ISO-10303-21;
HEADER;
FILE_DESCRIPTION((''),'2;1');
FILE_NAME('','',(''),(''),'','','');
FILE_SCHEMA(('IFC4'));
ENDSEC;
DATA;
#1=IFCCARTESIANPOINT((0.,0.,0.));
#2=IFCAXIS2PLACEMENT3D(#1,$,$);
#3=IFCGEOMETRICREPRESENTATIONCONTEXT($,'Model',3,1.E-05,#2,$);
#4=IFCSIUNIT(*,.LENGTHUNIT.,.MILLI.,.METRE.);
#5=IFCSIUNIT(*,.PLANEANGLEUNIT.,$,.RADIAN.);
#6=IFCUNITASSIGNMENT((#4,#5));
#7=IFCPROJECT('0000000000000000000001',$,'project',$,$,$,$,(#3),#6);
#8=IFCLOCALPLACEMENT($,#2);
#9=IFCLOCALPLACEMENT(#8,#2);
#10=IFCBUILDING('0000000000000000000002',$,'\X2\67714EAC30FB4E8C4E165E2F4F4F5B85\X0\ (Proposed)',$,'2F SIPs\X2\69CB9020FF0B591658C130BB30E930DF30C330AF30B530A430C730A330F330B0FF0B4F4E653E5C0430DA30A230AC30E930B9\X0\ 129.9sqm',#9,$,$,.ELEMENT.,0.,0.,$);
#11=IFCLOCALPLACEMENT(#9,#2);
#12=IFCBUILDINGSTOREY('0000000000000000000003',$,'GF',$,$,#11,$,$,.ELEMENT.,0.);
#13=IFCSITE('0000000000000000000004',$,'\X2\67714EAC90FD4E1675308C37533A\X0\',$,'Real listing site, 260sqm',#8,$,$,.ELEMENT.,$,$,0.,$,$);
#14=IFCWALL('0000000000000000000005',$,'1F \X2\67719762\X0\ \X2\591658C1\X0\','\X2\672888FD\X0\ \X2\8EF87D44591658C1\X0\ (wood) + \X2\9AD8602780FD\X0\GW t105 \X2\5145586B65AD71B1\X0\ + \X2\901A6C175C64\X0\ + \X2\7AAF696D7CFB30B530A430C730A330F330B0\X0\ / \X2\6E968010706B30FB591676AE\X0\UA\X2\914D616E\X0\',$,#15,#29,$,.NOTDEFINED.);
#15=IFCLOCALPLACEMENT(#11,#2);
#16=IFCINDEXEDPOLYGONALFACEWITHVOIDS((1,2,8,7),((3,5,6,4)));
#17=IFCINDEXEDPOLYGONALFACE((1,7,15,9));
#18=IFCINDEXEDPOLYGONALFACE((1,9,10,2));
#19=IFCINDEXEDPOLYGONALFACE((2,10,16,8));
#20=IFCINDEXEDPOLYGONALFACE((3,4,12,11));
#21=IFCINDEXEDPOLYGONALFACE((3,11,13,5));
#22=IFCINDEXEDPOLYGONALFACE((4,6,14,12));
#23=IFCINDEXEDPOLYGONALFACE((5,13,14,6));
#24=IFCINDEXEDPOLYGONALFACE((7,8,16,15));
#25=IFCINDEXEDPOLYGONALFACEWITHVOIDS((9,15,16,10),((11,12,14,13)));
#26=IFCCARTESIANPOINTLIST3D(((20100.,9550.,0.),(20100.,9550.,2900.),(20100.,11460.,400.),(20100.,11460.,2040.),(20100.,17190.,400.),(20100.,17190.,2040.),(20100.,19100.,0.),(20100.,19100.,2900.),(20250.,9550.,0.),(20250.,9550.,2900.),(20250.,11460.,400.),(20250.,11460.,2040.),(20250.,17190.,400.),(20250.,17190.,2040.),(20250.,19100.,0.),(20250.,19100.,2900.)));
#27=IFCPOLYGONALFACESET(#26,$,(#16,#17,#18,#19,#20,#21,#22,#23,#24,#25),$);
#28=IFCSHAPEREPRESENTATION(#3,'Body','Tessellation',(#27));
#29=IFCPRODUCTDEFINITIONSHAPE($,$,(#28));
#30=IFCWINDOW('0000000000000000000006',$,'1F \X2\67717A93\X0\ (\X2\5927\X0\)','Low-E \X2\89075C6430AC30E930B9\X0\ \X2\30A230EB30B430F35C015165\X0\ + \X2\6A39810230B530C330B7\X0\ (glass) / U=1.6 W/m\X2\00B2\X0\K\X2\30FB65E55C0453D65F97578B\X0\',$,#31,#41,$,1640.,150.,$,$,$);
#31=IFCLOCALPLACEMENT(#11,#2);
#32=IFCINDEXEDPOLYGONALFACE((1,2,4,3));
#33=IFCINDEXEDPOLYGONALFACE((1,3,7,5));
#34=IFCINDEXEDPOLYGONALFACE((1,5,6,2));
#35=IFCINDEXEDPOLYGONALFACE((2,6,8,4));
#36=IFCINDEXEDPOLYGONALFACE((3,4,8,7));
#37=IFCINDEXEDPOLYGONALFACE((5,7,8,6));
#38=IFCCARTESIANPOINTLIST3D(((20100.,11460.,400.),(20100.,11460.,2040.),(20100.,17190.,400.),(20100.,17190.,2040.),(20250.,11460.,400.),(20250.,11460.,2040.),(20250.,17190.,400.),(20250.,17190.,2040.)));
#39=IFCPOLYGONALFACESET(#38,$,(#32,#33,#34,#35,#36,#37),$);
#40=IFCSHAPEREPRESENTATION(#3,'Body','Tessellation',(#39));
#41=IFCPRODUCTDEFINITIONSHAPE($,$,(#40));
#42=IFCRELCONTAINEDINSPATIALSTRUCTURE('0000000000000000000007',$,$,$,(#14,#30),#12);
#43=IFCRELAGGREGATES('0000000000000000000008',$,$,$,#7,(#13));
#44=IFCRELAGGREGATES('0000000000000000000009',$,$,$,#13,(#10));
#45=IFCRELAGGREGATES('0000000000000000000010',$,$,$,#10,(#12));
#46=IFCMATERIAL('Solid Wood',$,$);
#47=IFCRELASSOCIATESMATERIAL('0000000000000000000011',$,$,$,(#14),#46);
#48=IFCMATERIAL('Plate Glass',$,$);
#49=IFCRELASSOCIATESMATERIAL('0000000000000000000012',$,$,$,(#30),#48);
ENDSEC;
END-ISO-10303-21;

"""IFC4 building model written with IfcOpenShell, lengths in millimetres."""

from ifc_helpers import new_model, si_unit, frame, frame_2d, origin, place, context, project, spatial, rectangle, extrude, material, element, fill, save


model = new_model("IFC4")

# Units and contexts
model_context = context("Model", 3, precision=1e-05, world=origin())
ifc_project = project(units=[si_unit("LENGTHUNIT", "METRE", prefix="MILLI"), si_unit("PLANEANGLEUNIT", "RADIAN")], contexts=[model_context])

# Site, building, storey
site_placement = place(None, origin())
site = spatial("IfcSite", under=ifc_project, at=site_placement, Name="東京都世田谷区", ObjectType="Real listing site, 260sqm", CompositionType="ELEMENT", RefElevation=0.0)
building_placement = place(site_placement, origin())
building = spatial("IfcBuilding", under=site, at=building_placement, Name="東京・二世帯住宅 (Proposed)", ObjectType="2F SIPs構造＋外壁セラミックサイディング＋低放射ペアガラス 129.9sqm", CompositionType="ELEMENT", ElevationOfRefHeight=0.0, ElevationOfTerrain=0.0)
storey_placement = place(building_placement, origin())
storey = spatial("IfcBuildingStorey", under=building, at=storey_placement, Name="GF", CompositionType="ELEMENT", Elevation=0.0)

# Shared definitions
ifc_material_1 = material(Name="Solid Wood")

# Wall, opening, window
wall_1_placement = place(storey_placement, frame((10050.0, 4775.0, 0.0)))
wall_1 = element("IfcWall", 1, at=wall_1_placement, inside=storey, material=ifc_material_1, Name="1F 東面 外壁", Description="木製 軸組外壁 (wood) + 高性能GW t105 充填断熱 + 通気層 + 窯業系サイディング / 準耐火・外皮UA配慮", PredefinedType="NOTDEFINED", context=model_context, shape_type="SweptSolid", body=[
    extrude(rectangle(XDim=150.0, YDim=9550.0, at=frame_2d((75.0, 4775.0))), frame((10050.0, 4775.0, 0.0)), (0.0, 0.0, 1.0), 2900.0),
])
opening_1_placement = place(storey_placement, frame((10050.0, 5730.0, 200.0)))
opening_1 = element("IfcOpeningElement", 2, at=opening_1_placement, cuts=wall_1, PredefinedType="NOTDEFINED", context=model_context, shape_type="SweptSolid", body=[
    extrude(rectangle(XDim=150.0, YDim=5730.0, at=frame_2d((75.0, 2865.0))), frame((10050.0, 5730.0, 200.0)), (0.0, 0.0, 1.0), 1640.0),
])
ifc_material_2 = material(Name="Plate Glass")
window_1_placement = place(storey_placement, frame((10050.0, 5730.0, 200.0)))
window_1 = element("IfcWindow", 3, at=window_1_placement, inside=storey, material=ifc_material_2, Name="1F 東窓 (大)", Description="Low-E 複層ガラス アルゴン封入 + 樹脂サッシ (glass) / U=1.6 W/m²K・日射取得型", OverallHeight=1640.0, OverallWidth=150.0, context=model_context, shape_type="SweptSolid", body=[
    extrude(rectangle(XDim=150.0, YDim=5730.0, at=frame_2d((75.0, 2865.0))), frame((10050.0, 5730.0, 200.0)), (0.0, 0.0, 1.0), 1640.0),
])
fill(opening_1, window_1)

save(model, "model.ifc")
